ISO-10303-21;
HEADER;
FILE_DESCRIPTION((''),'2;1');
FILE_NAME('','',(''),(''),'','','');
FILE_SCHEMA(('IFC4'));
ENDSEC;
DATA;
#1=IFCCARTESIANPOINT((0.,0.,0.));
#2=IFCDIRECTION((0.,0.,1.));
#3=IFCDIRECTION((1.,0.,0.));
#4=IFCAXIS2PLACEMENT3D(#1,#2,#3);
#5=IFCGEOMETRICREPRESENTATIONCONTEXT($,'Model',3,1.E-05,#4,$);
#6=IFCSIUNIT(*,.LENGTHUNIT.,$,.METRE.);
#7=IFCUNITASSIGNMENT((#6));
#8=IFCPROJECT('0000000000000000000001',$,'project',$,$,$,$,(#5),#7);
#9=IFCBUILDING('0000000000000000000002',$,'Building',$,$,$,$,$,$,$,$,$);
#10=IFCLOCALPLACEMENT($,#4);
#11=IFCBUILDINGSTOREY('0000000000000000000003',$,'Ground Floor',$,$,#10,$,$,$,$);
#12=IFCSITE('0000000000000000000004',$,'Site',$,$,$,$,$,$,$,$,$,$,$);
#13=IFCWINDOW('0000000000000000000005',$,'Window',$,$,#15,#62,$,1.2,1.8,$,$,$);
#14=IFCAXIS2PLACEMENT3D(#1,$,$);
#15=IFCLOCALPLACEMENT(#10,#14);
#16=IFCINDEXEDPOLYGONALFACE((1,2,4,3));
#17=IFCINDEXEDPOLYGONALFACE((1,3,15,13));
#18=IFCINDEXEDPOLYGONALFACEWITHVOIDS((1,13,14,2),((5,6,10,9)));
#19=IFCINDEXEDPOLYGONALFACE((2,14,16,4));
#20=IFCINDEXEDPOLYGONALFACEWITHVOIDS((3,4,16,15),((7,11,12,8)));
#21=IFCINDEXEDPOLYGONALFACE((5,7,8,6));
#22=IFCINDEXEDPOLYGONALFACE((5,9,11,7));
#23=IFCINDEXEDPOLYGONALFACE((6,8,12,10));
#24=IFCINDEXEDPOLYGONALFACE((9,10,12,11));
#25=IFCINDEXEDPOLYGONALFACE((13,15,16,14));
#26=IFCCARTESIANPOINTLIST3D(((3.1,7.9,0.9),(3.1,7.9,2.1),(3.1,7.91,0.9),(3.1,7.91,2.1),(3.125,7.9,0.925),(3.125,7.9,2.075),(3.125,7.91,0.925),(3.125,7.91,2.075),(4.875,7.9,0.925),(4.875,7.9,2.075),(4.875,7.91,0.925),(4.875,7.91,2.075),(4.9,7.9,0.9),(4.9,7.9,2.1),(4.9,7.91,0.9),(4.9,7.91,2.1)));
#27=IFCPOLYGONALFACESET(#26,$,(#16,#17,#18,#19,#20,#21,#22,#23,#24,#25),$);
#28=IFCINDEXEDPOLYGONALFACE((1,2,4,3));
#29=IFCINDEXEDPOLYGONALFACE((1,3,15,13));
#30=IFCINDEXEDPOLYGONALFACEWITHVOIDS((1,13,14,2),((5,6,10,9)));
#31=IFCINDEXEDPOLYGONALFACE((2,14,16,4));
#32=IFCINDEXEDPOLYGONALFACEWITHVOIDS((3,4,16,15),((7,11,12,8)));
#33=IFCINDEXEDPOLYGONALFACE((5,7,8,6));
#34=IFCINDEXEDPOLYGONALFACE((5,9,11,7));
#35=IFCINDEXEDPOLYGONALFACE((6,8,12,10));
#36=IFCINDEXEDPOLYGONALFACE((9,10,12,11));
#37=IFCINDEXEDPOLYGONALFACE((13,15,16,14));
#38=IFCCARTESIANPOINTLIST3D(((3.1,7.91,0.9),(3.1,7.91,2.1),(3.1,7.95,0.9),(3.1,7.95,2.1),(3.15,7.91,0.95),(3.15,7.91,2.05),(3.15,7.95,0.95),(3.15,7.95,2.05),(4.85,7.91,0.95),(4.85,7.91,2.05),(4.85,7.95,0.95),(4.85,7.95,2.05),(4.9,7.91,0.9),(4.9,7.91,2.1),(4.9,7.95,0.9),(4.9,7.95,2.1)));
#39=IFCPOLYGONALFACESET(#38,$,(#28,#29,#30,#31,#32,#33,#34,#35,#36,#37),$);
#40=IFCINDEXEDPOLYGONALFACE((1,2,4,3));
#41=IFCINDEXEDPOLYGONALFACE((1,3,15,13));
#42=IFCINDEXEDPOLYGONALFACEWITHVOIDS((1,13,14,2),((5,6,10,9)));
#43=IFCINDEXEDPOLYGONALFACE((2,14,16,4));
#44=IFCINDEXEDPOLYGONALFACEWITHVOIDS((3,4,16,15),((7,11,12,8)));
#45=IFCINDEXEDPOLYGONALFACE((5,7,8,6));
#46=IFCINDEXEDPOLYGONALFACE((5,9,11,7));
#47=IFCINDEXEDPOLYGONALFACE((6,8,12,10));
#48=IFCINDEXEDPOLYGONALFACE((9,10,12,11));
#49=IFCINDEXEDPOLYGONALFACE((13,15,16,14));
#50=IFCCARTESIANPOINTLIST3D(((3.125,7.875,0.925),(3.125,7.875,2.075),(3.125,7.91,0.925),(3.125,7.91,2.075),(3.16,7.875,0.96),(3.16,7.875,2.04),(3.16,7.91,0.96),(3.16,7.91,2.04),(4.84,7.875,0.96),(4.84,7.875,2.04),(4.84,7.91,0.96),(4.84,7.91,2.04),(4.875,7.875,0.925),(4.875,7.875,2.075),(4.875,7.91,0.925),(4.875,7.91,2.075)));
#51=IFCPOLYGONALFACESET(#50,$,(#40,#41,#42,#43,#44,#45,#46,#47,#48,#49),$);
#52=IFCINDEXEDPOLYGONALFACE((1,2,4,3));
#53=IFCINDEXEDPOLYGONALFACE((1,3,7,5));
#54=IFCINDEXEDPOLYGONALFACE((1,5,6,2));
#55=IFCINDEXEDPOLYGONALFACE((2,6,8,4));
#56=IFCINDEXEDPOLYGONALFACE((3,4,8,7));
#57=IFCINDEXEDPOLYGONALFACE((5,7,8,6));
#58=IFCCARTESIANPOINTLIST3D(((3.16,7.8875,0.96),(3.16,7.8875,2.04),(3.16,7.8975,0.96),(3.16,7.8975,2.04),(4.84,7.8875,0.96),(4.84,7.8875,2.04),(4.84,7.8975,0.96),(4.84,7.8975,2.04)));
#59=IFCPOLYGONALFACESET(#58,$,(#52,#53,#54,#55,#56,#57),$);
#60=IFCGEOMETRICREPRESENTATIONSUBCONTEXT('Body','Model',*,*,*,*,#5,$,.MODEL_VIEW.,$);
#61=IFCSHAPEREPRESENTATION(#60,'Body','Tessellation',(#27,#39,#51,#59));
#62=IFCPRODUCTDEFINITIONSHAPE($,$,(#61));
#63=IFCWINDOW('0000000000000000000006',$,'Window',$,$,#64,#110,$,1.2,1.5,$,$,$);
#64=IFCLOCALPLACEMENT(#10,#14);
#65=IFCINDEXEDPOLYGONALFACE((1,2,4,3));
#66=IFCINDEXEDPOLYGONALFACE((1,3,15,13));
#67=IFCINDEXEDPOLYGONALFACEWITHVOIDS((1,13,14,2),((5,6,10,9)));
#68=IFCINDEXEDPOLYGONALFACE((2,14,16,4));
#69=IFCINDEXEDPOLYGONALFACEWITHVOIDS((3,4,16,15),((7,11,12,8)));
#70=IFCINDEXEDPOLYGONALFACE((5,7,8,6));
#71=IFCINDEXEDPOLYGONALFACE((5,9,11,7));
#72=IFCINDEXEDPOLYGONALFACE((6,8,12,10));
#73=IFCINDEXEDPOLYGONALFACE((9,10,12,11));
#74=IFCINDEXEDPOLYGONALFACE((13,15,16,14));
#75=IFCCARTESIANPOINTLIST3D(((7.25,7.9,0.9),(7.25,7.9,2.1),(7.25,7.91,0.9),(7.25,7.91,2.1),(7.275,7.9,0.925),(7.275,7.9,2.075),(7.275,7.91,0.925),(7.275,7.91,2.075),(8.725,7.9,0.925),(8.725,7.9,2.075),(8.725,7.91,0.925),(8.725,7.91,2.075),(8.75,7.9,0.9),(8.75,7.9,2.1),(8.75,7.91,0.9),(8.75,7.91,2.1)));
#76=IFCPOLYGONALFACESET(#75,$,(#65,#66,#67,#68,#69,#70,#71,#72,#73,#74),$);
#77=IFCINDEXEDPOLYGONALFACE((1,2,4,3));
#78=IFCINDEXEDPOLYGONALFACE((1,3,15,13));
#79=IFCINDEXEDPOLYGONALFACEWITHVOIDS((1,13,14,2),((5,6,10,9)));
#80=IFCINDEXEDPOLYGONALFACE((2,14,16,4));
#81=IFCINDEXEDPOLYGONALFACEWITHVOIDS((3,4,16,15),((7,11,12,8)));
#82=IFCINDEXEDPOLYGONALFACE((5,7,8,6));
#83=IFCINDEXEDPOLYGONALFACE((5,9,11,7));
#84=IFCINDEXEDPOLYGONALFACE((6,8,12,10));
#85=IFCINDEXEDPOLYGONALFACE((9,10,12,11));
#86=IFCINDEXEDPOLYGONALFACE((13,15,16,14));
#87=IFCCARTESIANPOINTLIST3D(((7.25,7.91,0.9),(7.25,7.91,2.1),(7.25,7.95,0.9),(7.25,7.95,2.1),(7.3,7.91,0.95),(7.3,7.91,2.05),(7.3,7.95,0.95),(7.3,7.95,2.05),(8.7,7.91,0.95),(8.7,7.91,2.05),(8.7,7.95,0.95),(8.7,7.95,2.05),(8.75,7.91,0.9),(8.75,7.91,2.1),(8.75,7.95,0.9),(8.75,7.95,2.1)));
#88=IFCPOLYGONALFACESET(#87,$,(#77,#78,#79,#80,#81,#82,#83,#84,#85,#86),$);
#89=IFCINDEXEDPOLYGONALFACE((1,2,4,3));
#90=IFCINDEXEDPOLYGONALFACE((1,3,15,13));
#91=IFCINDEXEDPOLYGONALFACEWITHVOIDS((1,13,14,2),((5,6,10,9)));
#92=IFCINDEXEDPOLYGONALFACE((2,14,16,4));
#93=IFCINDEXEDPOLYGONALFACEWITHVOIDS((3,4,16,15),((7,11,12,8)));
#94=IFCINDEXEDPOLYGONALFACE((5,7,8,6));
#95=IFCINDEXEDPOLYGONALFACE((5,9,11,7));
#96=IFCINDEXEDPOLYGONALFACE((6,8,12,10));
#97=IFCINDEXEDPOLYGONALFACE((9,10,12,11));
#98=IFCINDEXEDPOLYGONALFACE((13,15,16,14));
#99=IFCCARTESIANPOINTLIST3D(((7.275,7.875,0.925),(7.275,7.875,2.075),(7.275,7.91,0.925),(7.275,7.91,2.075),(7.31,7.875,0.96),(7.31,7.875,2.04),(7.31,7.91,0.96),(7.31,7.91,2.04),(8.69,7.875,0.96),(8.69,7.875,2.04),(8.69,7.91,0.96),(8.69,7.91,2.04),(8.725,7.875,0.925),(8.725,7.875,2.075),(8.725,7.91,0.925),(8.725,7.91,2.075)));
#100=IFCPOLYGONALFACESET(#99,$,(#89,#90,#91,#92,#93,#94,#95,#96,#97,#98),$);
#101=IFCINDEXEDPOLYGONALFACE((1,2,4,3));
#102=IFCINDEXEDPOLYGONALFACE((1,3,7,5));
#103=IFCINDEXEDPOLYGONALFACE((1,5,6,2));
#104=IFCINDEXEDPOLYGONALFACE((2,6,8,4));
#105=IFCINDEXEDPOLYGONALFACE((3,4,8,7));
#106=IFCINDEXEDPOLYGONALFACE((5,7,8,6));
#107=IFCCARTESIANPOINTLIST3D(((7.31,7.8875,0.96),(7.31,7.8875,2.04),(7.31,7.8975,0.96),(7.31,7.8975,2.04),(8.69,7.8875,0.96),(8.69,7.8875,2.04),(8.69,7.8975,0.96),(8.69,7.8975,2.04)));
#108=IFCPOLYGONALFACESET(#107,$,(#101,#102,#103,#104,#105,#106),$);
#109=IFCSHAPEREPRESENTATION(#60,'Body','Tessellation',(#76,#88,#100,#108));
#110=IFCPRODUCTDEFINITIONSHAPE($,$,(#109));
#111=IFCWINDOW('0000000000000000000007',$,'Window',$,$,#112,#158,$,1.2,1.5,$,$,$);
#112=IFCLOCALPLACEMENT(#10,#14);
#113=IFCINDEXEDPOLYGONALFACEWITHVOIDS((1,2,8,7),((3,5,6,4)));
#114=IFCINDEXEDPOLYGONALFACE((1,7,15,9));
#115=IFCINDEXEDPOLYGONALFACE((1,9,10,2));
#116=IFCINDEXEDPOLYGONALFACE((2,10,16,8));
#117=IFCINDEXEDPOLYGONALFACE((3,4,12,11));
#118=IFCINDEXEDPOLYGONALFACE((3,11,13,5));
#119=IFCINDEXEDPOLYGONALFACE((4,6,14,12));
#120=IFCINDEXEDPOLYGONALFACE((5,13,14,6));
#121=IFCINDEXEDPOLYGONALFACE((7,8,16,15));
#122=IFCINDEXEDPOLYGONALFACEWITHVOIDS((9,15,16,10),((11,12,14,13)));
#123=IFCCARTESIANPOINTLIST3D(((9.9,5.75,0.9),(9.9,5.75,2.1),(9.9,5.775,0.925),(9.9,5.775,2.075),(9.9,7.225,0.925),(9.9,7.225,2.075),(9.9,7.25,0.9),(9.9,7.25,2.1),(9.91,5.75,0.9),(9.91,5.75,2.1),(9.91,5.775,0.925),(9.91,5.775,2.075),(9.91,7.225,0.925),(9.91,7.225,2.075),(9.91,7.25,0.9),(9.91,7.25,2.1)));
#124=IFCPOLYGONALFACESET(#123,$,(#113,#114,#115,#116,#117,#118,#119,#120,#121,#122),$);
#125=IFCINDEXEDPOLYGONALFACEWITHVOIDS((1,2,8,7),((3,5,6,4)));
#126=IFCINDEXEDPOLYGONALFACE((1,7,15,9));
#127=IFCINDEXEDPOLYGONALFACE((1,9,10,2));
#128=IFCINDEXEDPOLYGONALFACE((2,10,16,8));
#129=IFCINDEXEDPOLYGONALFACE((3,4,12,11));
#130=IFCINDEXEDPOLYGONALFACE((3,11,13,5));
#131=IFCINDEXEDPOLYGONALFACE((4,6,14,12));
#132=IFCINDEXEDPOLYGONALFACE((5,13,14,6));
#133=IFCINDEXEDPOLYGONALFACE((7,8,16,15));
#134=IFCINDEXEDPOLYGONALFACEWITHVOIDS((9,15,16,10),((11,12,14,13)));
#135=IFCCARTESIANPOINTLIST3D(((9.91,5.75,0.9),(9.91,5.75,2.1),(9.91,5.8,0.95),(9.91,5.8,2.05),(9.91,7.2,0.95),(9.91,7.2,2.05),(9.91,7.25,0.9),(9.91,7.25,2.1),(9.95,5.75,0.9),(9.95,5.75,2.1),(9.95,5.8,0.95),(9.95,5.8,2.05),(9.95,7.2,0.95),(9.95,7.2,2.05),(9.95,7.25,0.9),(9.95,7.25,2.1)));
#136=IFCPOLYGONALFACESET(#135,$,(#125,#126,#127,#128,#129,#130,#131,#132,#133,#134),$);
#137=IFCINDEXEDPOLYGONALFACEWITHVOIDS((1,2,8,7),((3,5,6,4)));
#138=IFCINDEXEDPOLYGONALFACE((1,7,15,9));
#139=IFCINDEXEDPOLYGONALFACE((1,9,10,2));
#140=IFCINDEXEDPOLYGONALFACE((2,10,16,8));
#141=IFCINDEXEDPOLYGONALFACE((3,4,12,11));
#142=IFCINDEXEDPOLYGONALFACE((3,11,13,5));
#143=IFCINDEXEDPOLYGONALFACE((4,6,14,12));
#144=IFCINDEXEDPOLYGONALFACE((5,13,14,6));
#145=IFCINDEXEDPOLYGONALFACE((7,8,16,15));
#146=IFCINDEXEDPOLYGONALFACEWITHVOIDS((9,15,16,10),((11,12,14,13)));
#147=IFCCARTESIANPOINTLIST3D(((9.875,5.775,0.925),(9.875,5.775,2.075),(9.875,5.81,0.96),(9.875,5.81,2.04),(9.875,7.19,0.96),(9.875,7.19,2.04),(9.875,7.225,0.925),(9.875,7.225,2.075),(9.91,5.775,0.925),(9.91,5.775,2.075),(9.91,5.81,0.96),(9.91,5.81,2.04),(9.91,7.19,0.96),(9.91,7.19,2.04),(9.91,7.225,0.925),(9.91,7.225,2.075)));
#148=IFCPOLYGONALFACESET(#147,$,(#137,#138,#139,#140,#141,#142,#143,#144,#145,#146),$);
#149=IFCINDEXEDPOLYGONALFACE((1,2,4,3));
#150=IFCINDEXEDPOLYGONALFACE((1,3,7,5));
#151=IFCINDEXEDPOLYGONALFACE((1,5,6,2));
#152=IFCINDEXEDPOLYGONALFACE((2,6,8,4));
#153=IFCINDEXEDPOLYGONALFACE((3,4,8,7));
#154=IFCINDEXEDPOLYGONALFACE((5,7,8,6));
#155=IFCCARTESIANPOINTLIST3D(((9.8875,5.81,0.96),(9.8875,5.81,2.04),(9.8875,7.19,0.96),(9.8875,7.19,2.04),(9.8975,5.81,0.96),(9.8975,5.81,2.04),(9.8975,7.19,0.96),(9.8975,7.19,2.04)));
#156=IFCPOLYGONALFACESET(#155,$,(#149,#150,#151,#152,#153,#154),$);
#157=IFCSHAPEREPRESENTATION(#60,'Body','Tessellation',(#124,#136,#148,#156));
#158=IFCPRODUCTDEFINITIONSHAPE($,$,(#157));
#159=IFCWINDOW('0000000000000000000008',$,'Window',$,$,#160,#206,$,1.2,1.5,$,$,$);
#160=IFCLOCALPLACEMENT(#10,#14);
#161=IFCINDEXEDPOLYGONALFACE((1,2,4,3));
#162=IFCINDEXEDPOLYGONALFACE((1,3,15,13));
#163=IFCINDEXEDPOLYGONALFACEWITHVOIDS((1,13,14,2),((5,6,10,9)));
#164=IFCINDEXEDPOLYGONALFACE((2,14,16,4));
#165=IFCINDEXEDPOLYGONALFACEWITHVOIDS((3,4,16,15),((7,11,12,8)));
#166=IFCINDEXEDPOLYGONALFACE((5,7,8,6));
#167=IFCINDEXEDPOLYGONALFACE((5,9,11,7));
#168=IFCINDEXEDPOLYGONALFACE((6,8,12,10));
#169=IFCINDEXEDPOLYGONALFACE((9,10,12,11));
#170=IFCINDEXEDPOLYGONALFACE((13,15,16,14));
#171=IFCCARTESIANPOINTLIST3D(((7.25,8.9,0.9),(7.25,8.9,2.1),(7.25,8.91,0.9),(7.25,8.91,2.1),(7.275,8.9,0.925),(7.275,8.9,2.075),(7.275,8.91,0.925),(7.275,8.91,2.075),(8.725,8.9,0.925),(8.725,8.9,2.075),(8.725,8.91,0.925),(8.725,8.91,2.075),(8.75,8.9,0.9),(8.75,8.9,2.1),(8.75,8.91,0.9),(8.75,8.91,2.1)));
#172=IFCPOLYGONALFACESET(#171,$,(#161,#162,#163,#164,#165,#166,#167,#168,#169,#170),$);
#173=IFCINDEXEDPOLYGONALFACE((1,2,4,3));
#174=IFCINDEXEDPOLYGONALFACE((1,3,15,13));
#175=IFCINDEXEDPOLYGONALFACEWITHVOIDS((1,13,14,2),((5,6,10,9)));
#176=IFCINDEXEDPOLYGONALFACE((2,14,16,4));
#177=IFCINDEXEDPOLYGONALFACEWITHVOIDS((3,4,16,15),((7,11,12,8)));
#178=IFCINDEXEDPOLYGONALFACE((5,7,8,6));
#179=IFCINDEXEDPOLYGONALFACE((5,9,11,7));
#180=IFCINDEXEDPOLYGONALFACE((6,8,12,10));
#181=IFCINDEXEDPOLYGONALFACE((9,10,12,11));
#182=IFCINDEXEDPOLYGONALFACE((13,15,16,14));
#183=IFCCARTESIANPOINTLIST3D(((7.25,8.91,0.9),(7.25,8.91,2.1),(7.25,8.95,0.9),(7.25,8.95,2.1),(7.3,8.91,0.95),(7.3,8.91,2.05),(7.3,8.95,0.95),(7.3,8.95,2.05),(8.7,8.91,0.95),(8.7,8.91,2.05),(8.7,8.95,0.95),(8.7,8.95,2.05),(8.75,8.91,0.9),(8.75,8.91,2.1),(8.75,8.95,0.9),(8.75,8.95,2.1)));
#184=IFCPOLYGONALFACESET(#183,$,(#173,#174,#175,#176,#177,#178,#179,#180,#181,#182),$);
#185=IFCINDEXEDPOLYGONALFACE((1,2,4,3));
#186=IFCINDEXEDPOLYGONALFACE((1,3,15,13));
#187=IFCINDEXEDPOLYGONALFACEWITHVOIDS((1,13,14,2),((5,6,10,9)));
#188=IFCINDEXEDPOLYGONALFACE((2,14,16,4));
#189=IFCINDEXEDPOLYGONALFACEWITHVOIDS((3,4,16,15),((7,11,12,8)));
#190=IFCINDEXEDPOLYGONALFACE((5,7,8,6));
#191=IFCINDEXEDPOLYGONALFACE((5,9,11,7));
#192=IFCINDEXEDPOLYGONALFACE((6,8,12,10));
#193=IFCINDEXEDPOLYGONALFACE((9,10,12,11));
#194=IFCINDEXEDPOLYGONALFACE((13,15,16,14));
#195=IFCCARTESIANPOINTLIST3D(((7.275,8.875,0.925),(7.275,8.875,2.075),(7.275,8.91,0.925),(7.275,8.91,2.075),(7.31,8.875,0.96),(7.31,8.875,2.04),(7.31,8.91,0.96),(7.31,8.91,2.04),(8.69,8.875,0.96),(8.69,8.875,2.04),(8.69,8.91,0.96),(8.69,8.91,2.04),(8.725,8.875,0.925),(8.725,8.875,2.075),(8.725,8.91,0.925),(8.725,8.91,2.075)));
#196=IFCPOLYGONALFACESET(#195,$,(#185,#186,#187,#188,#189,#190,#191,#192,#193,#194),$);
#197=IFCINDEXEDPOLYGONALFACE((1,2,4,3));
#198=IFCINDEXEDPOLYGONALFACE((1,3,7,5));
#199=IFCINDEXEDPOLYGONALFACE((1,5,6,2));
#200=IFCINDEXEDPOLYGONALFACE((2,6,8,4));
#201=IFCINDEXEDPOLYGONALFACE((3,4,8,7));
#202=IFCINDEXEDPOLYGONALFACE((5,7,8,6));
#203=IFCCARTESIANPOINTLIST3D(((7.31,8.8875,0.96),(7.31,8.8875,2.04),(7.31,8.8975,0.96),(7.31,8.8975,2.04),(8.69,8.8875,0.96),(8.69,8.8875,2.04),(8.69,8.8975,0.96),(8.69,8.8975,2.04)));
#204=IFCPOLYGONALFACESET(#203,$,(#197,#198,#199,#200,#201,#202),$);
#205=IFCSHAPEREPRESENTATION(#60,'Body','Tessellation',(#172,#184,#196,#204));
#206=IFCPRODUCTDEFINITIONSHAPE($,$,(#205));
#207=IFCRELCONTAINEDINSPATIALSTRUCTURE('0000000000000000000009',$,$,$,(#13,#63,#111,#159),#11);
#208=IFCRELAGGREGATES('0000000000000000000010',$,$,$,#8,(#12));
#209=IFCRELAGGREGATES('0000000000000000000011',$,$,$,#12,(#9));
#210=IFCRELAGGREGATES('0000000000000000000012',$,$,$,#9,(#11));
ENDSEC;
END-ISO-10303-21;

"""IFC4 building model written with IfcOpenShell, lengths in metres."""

from ifc_helpers import new_model, si_unit, frame, origin_with_axes, place, context, subcontext, project, spatial, line, indexed_curve, outline, extrude, element, save


model = new_model("IFC4")

# Units and contexts
model_context = context("Model", 3, precision=1e-05, world=origin_with_axes())
body_context = subcontext(model_context, "Body", "Model", "MODEL_VIEW")
ifc_project = project(units=[si_unit("LENGTHUNIT", "METRE")], contexts=[model_context])

# Site, building, storey
site = spatial("IfcSite", under=ifc_project, Name="Site")
building = spatial("IfcBuilding", under=site, Name="Building")
storey_placement = place(None, origin_with_axes())
storey = spatial("IfcBuildingStorey", under=building, at=storey_placement, Name="Ground Floor")

# Windows
window_1_placement = place(storey_placement, frame((4.9, 8.0, 0.9), z_axis=(0.0, 0.0, 1.0), x_axis=(-1.0, 0.0, 0.0)))
element("IfcWindow", 1, at=window_1_placement, inside=storey, Name="Window", OverallHeight=1.2, OverallWidth=1.8, context=body_context, shape_type="SweptSolid", body=[
    extrude(outline(indexed_curve([(0.0, 0.0), (1.8, 0.0), (1.8, 1.2), (0.0, 1.2)], segments=[line(1, 2, 3, 4, 1)]), holes=[indexed_curve([(0.025, 0.025), (1.775, 0.025), (1.775, 1.175), (0.025, 1.175)], segments=[line(1, 2, 3, 4, 1)])]), frame((0.0, 0.09, 0.0), z_axis=(0.0, -1.0, 0.0), x_axis=(1.0, 0.0, 0.0)), (0.0, 0.0, -1.0), 0.01),
    extrude(outline(indexed_curve([(0.0, 0.0), (1.8, 0.0), (1.8, 1.2), (0.0, 1.2)], segments=[line(1, 2, 3, 4, 1)]), holes=[indexed_curve([(0.05, 0.05), (1.75, 0.05), (1.75, 1.15), (0.05, 1.15)], segments=[line(1, 2, 3, 4, 1)])]), frame((0.0, 0.05, 0.0), z_axis=(0.0, -1.0, 0.0), x_axis=(1.0, 0.0, 0.0)), (0.0, 0.0, -1.0), 0.04),
    extrude(outline(indexed_curve([(0.0, 0.0), (1.75, 0.0), (1.75, 1.15), (0.0, 1.15)], segments=[line(1, 2, 3, 4, 1)]), holes=[indexed_curve([(0.035, 0.035), (1.715, 0.035), (1.715, 1.115), (0.035, 1.115)], segments=[line(1, 2, 3, 4, 1)])]), frame((0.025, 0.09, 0.025), z_axis=(0.0, -1.0, 0.0), x_axis=(1.0, 0.0, 0.0)), (0.0, 0.0, -1.0), 0.035),
    extrude(outline(indexed_curve([(0.035, 0.035), (1.715, 0.035), (1.715, 1.115), (0.035, 1.115)], segments=[line(1, 2, 3, 4, 1)])), frame((0.025, 0.1025, 0.025), z_axis=(0.0, -1.0, 0.0), x_axis=(1.0, 0.0, 0.0)), (0.0, 0.0, -1.0), 0.01),
])
for number, where, z_axis, x_axis, name in (
    (2, (8.75, 8.0, 0.9), (0.0, 0.0, 1.0), (-1.0, 0.0, 0.0), "Window"),
    (3, (10.0, 5.75, 0.9), (0.0, 0.0, 1.0), (0.0, 1.0, 0.0), "Window"),
    (4, (8.75, 9.0, 0.9), (0.0, 0.0, 1.0), (-1.0, 0.0, 0.0), "Window"),
):
    element("IfcWindow", number, at=place(storey_placement, frame(where, z_axis=z_axis, x_axis=x_axis)), inside=storey, Name=name, OverallHeight=1.2, OverallWidth=1.5, context=body_context, shape_type="SweptSolid", body=[
        extrude(outline(indexed_curve([(0.0, 0.0), (1.5, 0.0), (1.5, 1.2), (0.0, 1.2)], segments=[line(1, 2, 3, 4, 1)]), holes=[indexed_curve([(0.025, 0.025), (1.475, 0.025), (1.475, 1.175), (0.025, 1.175)], segments=[line(1, 2, 3, 4, 1)])]), frame((0.0, 0.09, 0.0), z_axis=(0.0, -1.0, 0.0), x_axis=(1.0, 0.0, 0.0)), (0.0, 0.0, -1.0), 0.01),
        extrude(outline(indexed_curve([(0.0, 0.0), (1.5, 0.0), (1.5, 1.2), (0.0, 1.2)], segments=[line(1, 2, 3, 4, 1)]), holes=[indexed_curve([(0.05, 0.05), (1.45, 0.05), (1.45, 1.15), (0.05, 1.15)], segments=[line(1, 2, 3, 4, 1)])]), frame((0.0, 0.05, 0.0), z_axis=(0.0, -1.0, 0.0), x_axis=(1.0, 0.0, 0.0)), (0.0, 0.0, -1.0), 0.04),
        extrude(outline(indexed_curve([(0.0, 0.0), (1.45, 0.0), (1.45, 1.15), (0.0, 1.15)], segments=[line(1, 2, 3, 4, 1)]), holes=[indexed_curve([(0.035, 0.035), (1.415, 0.035), (1.415, 1.115), (0.035, 1.115)], segments=[line(1, 2, 3, 4, 1)])]), frame((0.025, 0.09, 0.025), z_axis=(0.0, -1.0, 0.0), x_axis=(1.0, 0.0, 0.0)), (0.0, 0.0, -1.0), 0.035),
        extrude(outline(indexed_curve([(0.035, 0.035), (1.415, 0.035), (1.415, 1.115), (0.035, 1.115)], segments=[line(1, 2, 3, 4, 1)])), frame((0.025, 0.1025, 0.025), z_axis=(0.0, -1.0, 0.0), x_axis=(1.0, 0.0, 0.0)), (0.0, 0.0, -1.0), 0.01),
    ])

save(model, "model.ifc")
